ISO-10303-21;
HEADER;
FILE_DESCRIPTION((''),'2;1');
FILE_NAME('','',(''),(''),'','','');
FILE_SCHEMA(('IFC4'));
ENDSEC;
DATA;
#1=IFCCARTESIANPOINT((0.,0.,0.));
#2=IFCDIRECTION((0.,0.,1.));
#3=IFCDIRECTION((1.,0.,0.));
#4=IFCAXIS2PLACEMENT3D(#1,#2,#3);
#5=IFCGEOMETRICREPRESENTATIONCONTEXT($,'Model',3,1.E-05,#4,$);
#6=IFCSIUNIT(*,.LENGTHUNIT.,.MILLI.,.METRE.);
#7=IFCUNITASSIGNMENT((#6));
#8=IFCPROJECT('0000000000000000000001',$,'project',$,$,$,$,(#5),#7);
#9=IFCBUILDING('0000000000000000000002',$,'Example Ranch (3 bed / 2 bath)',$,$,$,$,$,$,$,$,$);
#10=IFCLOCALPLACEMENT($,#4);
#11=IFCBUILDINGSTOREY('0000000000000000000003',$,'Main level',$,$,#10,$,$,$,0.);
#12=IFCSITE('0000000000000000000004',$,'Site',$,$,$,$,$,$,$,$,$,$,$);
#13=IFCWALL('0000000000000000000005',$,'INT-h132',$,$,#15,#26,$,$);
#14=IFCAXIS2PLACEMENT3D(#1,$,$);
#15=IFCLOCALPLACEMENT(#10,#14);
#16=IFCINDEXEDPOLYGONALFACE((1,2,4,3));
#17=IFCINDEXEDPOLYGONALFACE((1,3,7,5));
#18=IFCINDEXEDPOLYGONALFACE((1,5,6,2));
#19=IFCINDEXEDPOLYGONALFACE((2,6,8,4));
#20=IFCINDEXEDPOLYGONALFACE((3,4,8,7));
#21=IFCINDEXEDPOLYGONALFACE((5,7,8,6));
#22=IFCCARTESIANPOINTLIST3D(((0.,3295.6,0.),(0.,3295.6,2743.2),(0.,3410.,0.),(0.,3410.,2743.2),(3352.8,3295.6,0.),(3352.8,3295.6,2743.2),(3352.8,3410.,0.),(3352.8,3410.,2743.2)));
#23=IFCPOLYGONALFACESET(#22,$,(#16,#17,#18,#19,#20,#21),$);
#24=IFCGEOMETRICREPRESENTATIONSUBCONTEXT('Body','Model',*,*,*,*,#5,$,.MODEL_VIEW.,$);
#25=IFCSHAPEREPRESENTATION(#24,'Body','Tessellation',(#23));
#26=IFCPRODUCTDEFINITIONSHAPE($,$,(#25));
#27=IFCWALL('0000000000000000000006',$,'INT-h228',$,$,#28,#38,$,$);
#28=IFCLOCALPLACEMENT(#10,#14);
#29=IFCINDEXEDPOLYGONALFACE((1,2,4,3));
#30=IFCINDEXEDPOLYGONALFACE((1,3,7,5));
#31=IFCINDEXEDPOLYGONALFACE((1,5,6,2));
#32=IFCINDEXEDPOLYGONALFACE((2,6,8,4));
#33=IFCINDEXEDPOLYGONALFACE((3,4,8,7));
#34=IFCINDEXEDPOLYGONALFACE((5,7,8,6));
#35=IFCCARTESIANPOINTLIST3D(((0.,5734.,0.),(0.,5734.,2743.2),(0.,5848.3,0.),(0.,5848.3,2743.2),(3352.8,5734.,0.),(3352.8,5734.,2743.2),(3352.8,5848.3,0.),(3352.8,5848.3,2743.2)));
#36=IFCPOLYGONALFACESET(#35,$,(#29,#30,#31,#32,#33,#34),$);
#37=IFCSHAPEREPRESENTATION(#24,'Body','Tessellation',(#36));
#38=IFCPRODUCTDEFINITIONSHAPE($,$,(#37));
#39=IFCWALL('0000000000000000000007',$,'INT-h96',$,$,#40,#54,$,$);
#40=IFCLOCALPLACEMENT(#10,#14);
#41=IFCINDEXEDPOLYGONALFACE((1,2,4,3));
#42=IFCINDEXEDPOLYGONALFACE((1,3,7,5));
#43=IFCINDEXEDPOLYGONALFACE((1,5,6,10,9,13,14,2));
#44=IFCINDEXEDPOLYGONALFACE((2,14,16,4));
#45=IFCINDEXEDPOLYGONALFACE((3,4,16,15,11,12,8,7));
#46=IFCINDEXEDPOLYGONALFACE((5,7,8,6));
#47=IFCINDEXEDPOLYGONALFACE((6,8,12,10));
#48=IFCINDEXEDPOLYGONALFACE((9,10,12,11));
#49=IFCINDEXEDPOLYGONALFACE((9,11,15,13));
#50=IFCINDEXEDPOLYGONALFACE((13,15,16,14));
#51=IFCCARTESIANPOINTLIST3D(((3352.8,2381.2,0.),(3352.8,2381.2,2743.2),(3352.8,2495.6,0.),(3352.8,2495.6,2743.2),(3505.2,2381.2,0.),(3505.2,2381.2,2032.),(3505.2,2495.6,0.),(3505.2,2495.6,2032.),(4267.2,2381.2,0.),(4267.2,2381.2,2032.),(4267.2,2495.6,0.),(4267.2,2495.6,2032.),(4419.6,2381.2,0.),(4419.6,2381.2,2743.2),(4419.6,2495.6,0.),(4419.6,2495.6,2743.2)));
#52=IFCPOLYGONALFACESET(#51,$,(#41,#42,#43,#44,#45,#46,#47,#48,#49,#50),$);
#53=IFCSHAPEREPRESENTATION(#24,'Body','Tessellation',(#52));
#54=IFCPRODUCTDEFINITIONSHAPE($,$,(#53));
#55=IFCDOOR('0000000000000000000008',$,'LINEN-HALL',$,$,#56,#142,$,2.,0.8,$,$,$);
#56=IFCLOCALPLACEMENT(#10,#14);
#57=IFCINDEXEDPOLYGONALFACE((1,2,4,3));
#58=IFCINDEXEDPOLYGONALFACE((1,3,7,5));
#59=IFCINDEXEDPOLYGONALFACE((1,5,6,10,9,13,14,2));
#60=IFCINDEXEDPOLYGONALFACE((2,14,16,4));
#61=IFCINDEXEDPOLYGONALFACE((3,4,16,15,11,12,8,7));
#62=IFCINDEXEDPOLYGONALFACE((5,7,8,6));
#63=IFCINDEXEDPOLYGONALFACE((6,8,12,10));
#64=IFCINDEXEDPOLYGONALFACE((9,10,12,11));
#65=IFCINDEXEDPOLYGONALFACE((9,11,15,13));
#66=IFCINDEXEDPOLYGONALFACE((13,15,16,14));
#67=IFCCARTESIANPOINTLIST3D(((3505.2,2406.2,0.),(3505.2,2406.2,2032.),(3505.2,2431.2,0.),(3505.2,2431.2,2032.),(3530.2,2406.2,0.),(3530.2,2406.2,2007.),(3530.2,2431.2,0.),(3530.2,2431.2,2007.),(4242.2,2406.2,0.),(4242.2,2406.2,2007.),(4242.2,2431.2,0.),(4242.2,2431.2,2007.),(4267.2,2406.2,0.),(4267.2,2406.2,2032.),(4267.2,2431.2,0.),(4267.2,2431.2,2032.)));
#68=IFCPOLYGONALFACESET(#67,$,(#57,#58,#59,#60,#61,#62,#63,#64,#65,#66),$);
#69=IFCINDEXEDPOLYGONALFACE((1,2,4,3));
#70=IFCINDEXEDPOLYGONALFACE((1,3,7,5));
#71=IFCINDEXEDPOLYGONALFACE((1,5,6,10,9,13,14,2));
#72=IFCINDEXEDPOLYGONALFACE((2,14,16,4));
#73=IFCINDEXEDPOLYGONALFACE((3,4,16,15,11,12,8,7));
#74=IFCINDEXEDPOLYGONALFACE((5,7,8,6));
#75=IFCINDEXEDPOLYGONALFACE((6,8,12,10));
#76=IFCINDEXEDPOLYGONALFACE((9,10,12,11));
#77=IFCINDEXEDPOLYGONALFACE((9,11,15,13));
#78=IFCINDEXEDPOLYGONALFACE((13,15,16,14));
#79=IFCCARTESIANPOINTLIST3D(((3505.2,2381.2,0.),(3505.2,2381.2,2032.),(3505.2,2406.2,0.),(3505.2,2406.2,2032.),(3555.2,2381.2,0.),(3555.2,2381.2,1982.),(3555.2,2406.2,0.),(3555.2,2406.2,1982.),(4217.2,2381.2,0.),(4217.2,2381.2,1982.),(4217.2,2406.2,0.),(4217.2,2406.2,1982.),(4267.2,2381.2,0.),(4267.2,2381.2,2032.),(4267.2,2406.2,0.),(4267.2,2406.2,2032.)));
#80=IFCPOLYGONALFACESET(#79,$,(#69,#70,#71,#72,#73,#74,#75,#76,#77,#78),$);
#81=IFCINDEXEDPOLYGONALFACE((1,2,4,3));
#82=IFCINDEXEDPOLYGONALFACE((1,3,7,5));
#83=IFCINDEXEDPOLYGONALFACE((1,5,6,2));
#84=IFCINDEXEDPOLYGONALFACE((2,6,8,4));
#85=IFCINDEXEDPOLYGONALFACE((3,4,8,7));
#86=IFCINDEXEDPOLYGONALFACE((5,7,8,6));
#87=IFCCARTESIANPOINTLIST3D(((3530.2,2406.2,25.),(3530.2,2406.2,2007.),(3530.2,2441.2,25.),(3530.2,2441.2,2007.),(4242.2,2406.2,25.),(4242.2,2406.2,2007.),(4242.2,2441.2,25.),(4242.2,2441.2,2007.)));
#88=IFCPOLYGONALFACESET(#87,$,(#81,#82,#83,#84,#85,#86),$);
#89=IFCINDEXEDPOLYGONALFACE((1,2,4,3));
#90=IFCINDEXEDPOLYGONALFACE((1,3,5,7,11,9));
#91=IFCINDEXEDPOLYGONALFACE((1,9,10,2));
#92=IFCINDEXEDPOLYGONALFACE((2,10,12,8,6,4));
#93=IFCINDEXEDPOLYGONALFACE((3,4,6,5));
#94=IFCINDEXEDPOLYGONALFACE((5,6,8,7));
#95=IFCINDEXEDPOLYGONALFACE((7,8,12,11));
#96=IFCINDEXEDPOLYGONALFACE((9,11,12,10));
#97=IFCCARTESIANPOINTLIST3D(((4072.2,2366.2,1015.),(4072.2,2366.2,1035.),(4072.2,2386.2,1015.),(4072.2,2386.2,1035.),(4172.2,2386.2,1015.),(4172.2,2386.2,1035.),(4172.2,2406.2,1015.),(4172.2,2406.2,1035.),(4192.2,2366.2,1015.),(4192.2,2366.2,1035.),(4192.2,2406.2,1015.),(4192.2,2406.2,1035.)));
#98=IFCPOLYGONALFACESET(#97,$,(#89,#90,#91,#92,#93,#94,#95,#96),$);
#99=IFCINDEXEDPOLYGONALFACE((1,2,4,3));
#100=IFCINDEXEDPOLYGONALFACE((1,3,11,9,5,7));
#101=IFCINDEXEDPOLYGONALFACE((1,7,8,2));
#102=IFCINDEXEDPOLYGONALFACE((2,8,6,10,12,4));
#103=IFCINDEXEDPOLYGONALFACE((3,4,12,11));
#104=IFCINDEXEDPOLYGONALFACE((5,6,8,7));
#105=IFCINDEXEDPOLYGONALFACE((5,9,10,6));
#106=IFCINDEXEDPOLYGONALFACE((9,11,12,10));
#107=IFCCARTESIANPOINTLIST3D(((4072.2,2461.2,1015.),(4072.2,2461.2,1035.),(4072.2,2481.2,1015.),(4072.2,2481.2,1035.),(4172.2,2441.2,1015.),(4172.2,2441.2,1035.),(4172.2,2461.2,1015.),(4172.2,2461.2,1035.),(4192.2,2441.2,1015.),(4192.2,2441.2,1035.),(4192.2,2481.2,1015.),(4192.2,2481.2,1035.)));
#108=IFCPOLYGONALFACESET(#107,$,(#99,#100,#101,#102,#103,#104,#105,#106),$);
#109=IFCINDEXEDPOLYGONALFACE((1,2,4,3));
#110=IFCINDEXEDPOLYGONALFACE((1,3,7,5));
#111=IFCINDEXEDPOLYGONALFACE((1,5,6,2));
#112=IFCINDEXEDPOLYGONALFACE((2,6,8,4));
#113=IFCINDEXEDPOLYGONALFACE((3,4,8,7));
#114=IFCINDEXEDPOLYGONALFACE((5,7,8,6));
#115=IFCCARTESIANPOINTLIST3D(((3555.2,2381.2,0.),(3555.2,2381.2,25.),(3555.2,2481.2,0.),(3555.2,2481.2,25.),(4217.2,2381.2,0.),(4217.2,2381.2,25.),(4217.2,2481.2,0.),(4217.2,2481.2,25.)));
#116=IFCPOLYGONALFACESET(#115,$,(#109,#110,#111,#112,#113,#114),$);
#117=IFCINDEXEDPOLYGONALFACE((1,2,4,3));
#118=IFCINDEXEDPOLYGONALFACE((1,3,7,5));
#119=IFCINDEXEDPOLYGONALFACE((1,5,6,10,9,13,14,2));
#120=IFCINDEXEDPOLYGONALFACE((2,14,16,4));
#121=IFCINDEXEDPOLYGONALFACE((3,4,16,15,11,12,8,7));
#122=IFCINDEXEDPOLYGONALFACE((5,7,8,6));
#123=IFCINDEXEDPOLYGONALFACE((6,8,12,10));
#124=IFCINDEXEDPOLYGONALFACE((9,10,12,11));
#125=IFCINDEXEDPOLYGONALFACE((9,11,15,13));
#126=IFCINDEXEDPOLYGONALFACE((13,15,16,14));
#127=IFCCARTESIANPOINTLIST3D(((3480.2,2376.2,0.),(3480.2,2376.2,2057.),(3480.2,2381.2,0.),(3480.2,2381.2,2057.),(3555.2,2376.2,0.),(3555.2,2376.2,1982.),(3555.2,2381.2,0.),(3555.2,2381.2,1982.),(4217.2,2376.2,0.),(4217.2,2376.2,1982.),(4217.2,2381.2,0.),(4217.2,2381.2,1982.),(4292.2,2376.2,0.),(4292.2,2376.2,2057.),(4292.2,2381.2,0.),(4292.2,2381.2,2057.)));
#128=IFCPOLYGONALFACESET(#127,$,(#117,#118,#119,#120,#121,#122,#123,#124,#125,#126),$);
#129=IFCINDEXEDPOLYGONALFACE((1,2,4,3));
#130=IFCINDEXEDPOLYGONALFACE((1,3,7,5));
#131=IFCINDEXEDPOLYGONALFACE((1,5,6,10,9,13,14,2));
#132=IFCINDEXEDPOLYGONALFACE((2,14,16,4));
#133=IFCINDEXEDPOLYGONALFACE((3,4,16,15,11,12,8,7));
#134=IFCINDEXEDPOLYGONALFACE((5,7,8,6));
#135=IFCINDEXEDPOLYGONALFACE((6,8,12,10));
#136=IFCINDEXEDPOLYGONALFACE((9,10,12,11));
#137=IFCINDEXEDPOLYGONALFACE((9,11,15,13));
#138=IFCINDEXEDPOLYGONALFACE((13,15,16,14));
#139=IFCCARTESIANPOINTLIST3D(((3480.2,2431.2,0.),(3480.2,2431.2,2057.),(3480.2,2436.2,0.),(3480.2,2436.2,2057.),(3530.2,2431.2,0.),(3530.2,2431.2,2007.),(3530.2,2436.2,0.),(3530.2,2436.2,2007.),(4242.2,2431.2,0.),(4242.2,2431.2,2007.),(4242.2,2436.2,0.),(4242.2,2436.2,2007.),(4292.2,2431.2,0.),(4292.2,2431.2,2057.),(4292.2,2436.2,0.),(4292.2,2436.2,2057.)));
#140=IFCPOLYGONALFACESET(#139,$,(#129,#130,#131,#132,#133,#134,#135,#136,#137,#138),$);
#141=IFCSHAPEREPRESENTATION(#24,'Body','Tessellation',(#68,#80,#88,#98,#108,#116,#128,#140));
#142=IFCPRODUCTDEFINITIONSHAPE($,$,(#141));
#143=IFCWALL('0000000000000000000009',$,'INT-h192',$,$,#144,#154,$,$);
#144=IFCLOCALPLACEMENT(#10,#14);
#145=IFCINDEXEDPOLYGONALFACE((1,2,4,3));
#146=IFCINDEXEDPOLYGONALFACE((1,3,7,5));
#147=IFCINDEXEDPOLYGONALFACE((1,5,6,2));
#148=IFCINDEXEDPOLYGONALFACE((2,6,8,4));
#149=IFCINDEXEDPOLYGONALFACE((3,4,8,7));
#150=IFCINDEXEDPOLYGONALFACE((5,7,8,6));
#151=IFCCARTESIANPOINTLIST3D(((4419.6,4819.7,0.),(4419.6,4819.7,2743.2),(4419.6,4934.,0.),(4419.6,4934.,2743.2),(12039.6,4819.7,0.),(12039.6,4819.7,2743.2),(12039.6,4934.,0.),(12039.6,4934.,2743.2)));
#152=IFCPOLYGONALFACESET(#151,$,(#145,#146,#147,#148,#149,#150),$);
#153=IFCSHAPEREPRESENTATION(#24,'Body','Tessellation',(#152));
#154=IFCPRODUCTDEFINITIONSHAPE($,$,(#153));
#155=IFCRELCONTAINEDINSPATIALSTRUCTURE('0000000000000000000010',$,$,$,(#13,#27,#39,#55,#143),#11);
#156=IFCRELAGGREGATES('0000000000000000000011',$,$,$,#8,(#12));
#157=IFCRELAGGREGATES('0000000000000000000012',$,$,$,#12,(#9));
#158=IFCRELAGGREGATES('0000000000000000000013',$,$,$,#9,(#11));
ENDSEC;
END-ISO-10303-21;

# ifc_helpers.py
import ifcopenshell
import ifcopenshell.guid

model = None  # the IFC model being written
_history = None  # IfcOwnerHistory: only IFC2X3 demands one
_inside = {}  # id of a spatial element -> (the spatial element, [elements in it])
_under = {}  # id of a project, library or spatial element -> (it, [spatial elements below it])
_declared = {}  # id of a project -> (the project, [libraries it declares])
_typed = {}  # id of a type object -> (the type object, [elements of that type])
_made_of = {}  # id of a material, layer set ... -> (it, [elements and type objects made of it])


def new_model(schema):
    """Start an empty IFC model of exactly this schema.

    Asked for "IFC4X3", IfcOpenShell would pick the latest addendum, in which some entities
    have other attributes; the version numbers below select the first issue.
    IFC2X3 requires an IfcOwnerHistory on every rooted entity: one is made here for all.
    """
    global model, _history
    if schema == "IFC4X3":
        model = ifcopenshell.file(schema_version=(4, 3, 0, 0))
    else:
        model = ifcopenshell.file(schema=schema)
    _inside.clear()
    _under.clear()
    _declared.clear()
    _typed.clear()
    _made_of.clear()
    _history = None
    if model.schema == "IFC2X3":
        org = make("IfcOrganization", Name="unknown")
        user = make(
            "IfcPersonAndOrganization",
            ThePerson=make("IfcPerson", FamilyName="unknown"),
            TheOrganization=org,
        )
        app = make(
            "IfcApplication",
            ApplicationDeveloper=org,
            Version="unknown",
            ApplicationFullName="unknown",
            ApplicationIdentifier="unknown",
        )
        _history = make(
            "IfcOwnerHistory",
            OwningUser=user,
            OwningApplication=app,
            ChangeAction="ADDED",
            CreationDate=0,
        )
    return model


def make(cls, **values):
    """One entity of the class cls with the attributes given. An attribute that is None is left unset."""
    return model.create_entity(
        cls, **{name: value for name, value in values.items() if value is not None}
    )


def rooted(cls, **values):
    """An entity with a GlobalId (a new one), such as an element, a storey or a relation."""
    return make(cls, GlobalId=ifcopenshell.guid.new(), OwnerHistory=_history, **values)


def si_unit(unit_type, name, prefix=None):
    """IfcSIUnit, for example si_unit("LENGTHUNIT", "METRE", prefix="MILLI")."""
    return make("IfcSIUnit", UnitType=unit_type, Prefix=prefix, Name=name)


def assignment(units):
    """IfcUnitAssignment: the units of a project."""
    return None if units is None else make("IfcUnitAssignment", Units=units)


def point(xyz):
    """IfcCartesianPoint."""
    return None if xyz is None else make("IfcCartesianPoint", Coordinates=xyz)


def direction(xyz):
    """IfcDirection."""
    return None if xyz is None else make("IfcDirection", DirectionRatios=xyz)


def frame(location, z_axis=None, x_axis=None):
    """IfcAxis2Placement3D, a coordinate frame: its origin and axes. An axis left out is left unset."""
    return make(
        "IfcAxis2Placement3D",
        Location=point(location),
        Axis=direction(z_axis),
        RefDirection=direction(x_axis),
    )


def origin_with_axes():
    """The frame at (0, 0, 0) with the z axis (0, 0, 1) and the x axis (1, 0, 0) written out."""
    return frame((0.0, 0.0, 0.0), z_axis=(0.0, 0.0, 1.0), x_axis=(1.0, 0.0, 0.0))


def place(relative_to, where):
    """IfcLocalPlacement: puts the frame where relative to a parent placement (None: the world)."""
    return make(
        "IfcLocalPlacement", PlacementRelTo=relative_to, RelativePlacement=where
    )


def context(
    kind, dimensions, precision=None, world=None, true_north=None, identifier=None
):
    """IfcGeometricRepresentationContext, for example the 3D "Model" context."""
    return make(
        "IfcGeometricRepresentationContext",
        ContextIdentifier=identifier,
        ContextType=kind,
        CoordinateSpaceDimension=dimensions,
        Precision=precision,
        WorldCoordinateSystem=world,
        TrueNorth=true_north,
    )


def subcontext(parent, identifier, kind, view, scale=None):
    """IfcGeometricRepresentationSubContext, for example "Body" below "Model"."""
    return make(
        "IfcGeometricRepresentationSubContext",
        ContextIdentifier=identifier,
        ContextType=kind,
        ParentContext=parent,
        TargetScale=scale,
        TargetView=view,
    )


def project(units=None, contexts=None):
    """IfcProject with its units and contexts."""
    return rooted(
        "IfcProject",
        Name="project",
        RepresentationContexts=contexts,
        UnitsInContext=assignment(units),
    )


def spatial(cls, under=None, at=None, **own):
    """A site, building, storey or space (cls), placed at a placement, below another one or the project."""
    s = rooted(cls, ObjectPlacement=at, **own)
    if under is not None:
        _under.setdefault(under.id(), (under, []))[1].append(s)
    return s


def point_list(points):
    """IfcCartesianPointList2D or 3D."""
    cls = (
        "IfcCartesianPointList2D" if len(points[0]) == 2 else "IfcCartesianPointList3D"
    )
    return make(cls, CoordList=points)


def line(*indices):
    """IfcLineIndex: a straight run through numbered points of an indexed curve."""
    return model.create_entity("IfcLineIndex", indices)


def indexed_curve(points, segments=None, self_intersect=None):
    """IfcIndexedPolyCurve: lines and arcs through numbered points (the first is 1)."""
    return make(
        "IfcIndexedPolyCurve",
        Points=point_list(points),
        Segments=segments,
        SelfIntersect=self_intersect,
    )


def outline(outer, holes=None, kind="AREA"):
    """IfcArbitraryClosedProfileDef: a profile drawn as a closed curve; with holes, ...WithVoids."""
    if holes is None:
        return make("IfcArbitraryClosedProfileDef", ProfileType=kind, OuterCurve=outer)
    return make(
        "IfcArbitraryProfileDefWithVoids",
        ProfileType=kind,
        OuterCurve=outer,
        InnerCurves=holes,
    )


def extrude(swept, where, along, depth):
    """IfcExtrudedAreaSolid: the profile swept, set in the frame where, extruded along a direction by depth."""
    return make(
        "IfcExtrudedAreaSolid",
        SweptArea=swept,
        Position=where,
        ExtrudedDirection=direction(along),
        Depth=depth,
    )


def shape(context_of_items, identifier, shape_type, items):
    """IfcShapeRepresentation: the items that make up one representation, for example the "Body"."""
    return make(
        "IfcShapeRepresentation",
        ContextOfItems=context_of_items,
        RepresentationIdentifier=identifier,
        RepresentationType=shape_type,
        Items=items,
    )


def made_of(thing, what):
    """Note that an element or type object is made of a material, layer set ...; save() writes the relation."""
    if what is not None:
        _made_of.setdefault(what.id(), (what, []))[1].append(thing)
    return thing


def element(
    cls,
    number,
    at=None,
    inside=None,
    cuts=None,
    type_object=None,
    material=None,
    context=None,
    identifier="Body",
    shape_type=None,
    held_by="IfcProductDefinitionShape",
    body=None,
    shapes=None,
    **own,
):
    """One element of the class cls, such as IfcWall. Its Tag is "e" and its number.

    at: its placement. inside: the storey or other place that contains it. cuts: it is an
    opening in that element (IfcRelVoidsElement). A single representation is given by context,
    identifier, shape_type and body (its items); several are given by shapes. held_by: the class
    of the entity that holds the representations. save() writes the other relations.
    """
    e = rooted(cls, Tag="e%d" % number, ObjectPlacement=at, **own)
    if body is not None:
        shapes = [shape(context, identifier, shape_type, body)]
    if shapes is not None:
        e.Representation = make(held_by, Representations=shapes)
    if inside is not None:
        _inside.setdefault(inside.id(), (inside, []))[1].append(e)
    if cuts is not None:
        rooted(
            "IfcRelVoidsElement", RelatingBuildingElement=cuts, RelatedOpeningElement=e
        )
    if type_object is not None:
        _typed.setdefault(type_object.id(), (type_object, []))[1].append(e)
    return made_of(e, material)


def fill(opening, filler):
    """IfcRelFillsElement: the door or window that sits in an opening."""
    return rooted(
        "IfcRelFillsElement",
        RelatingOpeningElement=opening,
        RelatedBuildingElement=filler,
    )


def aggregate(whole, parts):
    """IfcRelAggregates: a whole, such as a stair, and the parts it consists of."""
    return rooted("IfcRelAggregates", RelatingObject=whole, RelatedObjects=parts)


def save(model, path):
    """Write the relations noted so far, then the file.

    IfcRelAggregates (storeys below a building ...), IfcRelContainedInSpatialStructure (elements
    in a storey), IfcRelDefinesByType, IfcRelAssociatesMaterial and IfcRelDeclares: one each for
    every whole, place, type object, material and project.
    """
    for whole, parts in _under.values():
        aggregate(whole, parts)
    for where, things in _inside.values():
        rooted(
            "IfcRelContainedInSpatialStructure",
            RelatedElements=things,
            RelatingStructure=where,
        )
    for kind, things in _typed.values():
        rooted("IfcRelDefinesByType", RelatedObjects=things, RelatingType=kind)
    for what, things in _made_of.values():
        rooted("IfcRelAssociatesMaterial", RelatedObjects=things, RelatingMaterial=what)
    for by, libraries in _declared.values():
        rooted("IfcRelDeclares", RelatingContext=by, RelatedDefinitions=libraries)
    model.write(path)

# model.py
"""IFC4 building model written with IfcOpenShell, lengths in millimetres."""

from ifc_helpers import new_model, si_unit, frame, origin_with_axes, place, context, subcontext, project, spatial, line, indexed_curve, outline, extrude, element, fill, save


model = new_model("IFC4")

# Units and contexts
model_context = context("Model", 3, precision=1e-05, world=origin_with_axes())
body_context = subcontext(model_context, "Body", "Model", "MODEL_VIEW")
ifc_project = project(units=[si_unit("LENGTHUNIT", "METRE", prefix="MILLI")], contexts=[model_context])

# Site, building, storey
site = spatial("IfcSite", under=ifc_project, Name="Site")
building = spatial("IfcBuilding", under=site, Name="Example Ranch (3 bed / 2 bath)")
storey_placement = place(None, origin_with_axes())
storey = spatial("IfcBuildingStorey", under=building, at=storey_placement, Name="Main level", Elevation=0.0)

# Walls
for number, where, z_axis, x_axis, name in (
    (1, (0.0, 3295.6, 0.0), (0.0, 0.0, 1.0), (1.0, 0.0, 0.0), "INT-h132"),
    (2, (0.0, 5734.1, 0.0), (0.0, 0.0, 1.0), (1.0, 0.0, 0.0), "INT-h228"),
):
    element("IfcWall", number, at=place(storey_placement, frame(where, z_axis=z_axis, x_axis=x_axis)), inside=storey, Name=name, context=body_context, shape_type="SweptSolid", body=[
        extrude(outline(indexed_curve([(0.0, 0.0), (0.0, 114.3), (3352.8, 114.3), (3352.8, 0.0), (0.0, 0.0)], self_intersect=False)), origin_with_axes(), (0.0, 0.0, 1.0), 2743.2),
    ])

# Wall, opening, door
wall_1_placement = place(storey_placement, frame((3352.8, 2381.2, 0.0), z_axis=(0.0, 0.0, 1.0), x_axis=(1.0, 0.0, 0.0)))
wall_1 = element("IfcWall", 3, at=wall_1_placement, inside=storey, Name="INT-h96", context=body_context, shape_type="SweptSolid", body=[
    extrude(outline(indexed_curve([(0.0, 0.0), (0.0, 114.3), (1066.8, 114.3), (1066.8, 0.0), (0.0, 0.0)], self_intersect=False)), origin_with_axes(), (0.0, 0.0, 1.0), 2743.2),
])
opening_1_placement = place(wall_1_placement, frame((152.4, 0.0, 0.0), z_axis=(0.0, 0.0, 1.0), x_axis=(1.0, 0.0, 0.0)))
opening_1 = element("IfcOpeningElement", 4, at=opening_1_placement, cuts=wall_1, context=body_context, shape_type="SweptSolid", body=[
    extrude(outline(indexed_curve([(0.0, 0.0), (0.0, 114.3), (762.0, 114.3), (762.0, 0.0), (0.0, 0.0)], self_intersect=False)), origin_with_axes(), (0.0, 0.0, 1.0), 2032.0),
])
door_1_placement = place(storey_placement, frame((3505.2, 2381.2, 0.0), z_axis=(0.0, 0.0, 1.0), x_axis=(1.0, 0.0, 0.0)))
door_1 = element("IfcDoor", 5, at=door_1_placement, inside=storey, Name="LINEN-HALL", OverallHeight=2.0, OverallWidth=0.8, context=body_context, shape_type="SweptSolid", body=[
    extrude(outline(indexed_curve([(0.0, 0.0), (0.0, 2032.0), (762.0, 2032.0), (762.0, 0.0), (737.0, 0.0), (737.0, 2007.0), (25.0, 2007.0), (25.0, 0.0)], segments=[line(1, 2, 3, 4, 5, 6, 7, 8, 1)])), frame((0.0, 25.0, 0.0), z_axis=(0.0, -1.0, 0.0), x_axis=(1.0, 0.0, 0.0)), (0.0, 0.0, -1.0), 25.0),
    extrude(outline(indexed_curve([(0.0, 0.0), (0.0, 2032.0), (762.0, 2032.0), (762.0, 0.0), (712.0, 0.0), (712.0, 1982.0), (50.0, 1982.0), (50.0, 0.0)], segments=[line(1, 2, 3, 4, 5, 6, 7, 8, 1)])), frame((0.0, 0.0, 0.0), z_axis=(0.0, -1.0, 0.0), x_axis=(1.0, 0.0, 0.0)), (0.0, 0.0, -1.0), 25.0),
    extrude(outline(indexed_curve([(0.0, 0.0), (712.0, 0.0), (712.0, 35.0), (0.0, 35.0)], segments=[line(1, 2, 3, 4, 1)])), frame((25.0, 25.0, 25.0), z_axis=(0.0, 0.0, 1.0), x_axis=(1.0, 0.0, 0.0)), (0.0, 0.0, 1.0), 1982.0),
    extrude(outline(indexed_curve([(0.0, 0.0), (0.0, -40.0), (-120.0, -40.0), (-120.0, -20.0), (-20.0, -20.0), (-20.0, 0.0)], segments=[line(1, 2, 3, 4, 5, 6, 1)])), frame((687.0, 25.0, 1015.0), z_axis=(0.0, 0.0, 1.0), x_axis=(1.0, 0.0, 0.0)), (0.0, 0.0, 1.0), 20.0),
    extrude(outline(indexed_curve([(0.0, 0.0), (0.0, 40.0), (-120.0, 40.0), (-120.0, 20.0), (-20.0, 20.0), (-20.0, 0.0)], segments=[line(1, 2, 3, 4, 5, 6, 1)])), frame((687.0, 60.0, 1015.0), z_axis=(0.0, 0.0, 1.0), x_axis=(1.0, 0.0, 0.0)), (0.0, 0.0, 1.0), 20.0),
    extrude(outline(indexed_curve([(0.0, 0.0), (662.0, 0.0), (662.0, 100.0), (0.0, 100.0)], segments=[line(1, 2, 3, 4, 1)])), frame((50.0, 0.0, 0.0), z_axis=(0.0, 0.0, 1.0), x_axis=(1.0, 0.0, 0.0)), (0.0, 0.0, 1.0), 25.0),
    extrude(outline(indexed_curve([(0.0, 0.0), (0.0, 2057.0), (812.0, 2057.0), (812.0, 0.0), (737.0, 0.0), (737.0, 1982.0), (75.0, 1982.0), (75.0, 0.0)], segments=[line(1, 2, 3, 4, 5, 6, 7, 8, 1)])), frame((-25.0, -5.0, 0.0), z_axis=(0.0, -1.0, 0.0), x_axis=(1.0, 0.0, 0.0)), (0.0, 0.0, -1.0), 5.0),
    extrude(outline(indexed_curve([(0.0, 0.0), (0.0, 2057.0), (812.0, 2057.0), (812.0, 0.0), (762.0, 0.0), (762.0, 2007.0), (50.0, 2007.0), (50.0, 0.0)], segments=[line(1, 2, 3, 4, 5, 6, 7, 8, 1)])), frame((-25.0, 50.0, 0.0), z_axis=(0.0, -1.0, 0.0), x_axis=(1.0, 0.0, 0.0)), (0.0, 0.0, -1.0), 5.0),
])
fill(opening_1, door_1)

# Wall
wall_2_placement = place(storey_placement, frame((4419.6, 4819.7, 0.0), z_axis=(0.0, 0.0, 1.0), x_axis=(1.0, 0.0, 0.0)))
element("IfcWall", 6, at=wall_2_placement, inside=storey, Name="INT-h192", context=body_context, shape_type="SweptSolid", body=[
    extrude(outline(indexed_curve([(0.0, 0.0), (0.0, 114.3), (7620.0, 114.3), (7620.0, 0.0), (0.0, 0.0)], self_intersect=False)), origin_with_axes(), (0.0, 0.0, 1.0), 2743.2),
])

save(model, "model.ifc")
